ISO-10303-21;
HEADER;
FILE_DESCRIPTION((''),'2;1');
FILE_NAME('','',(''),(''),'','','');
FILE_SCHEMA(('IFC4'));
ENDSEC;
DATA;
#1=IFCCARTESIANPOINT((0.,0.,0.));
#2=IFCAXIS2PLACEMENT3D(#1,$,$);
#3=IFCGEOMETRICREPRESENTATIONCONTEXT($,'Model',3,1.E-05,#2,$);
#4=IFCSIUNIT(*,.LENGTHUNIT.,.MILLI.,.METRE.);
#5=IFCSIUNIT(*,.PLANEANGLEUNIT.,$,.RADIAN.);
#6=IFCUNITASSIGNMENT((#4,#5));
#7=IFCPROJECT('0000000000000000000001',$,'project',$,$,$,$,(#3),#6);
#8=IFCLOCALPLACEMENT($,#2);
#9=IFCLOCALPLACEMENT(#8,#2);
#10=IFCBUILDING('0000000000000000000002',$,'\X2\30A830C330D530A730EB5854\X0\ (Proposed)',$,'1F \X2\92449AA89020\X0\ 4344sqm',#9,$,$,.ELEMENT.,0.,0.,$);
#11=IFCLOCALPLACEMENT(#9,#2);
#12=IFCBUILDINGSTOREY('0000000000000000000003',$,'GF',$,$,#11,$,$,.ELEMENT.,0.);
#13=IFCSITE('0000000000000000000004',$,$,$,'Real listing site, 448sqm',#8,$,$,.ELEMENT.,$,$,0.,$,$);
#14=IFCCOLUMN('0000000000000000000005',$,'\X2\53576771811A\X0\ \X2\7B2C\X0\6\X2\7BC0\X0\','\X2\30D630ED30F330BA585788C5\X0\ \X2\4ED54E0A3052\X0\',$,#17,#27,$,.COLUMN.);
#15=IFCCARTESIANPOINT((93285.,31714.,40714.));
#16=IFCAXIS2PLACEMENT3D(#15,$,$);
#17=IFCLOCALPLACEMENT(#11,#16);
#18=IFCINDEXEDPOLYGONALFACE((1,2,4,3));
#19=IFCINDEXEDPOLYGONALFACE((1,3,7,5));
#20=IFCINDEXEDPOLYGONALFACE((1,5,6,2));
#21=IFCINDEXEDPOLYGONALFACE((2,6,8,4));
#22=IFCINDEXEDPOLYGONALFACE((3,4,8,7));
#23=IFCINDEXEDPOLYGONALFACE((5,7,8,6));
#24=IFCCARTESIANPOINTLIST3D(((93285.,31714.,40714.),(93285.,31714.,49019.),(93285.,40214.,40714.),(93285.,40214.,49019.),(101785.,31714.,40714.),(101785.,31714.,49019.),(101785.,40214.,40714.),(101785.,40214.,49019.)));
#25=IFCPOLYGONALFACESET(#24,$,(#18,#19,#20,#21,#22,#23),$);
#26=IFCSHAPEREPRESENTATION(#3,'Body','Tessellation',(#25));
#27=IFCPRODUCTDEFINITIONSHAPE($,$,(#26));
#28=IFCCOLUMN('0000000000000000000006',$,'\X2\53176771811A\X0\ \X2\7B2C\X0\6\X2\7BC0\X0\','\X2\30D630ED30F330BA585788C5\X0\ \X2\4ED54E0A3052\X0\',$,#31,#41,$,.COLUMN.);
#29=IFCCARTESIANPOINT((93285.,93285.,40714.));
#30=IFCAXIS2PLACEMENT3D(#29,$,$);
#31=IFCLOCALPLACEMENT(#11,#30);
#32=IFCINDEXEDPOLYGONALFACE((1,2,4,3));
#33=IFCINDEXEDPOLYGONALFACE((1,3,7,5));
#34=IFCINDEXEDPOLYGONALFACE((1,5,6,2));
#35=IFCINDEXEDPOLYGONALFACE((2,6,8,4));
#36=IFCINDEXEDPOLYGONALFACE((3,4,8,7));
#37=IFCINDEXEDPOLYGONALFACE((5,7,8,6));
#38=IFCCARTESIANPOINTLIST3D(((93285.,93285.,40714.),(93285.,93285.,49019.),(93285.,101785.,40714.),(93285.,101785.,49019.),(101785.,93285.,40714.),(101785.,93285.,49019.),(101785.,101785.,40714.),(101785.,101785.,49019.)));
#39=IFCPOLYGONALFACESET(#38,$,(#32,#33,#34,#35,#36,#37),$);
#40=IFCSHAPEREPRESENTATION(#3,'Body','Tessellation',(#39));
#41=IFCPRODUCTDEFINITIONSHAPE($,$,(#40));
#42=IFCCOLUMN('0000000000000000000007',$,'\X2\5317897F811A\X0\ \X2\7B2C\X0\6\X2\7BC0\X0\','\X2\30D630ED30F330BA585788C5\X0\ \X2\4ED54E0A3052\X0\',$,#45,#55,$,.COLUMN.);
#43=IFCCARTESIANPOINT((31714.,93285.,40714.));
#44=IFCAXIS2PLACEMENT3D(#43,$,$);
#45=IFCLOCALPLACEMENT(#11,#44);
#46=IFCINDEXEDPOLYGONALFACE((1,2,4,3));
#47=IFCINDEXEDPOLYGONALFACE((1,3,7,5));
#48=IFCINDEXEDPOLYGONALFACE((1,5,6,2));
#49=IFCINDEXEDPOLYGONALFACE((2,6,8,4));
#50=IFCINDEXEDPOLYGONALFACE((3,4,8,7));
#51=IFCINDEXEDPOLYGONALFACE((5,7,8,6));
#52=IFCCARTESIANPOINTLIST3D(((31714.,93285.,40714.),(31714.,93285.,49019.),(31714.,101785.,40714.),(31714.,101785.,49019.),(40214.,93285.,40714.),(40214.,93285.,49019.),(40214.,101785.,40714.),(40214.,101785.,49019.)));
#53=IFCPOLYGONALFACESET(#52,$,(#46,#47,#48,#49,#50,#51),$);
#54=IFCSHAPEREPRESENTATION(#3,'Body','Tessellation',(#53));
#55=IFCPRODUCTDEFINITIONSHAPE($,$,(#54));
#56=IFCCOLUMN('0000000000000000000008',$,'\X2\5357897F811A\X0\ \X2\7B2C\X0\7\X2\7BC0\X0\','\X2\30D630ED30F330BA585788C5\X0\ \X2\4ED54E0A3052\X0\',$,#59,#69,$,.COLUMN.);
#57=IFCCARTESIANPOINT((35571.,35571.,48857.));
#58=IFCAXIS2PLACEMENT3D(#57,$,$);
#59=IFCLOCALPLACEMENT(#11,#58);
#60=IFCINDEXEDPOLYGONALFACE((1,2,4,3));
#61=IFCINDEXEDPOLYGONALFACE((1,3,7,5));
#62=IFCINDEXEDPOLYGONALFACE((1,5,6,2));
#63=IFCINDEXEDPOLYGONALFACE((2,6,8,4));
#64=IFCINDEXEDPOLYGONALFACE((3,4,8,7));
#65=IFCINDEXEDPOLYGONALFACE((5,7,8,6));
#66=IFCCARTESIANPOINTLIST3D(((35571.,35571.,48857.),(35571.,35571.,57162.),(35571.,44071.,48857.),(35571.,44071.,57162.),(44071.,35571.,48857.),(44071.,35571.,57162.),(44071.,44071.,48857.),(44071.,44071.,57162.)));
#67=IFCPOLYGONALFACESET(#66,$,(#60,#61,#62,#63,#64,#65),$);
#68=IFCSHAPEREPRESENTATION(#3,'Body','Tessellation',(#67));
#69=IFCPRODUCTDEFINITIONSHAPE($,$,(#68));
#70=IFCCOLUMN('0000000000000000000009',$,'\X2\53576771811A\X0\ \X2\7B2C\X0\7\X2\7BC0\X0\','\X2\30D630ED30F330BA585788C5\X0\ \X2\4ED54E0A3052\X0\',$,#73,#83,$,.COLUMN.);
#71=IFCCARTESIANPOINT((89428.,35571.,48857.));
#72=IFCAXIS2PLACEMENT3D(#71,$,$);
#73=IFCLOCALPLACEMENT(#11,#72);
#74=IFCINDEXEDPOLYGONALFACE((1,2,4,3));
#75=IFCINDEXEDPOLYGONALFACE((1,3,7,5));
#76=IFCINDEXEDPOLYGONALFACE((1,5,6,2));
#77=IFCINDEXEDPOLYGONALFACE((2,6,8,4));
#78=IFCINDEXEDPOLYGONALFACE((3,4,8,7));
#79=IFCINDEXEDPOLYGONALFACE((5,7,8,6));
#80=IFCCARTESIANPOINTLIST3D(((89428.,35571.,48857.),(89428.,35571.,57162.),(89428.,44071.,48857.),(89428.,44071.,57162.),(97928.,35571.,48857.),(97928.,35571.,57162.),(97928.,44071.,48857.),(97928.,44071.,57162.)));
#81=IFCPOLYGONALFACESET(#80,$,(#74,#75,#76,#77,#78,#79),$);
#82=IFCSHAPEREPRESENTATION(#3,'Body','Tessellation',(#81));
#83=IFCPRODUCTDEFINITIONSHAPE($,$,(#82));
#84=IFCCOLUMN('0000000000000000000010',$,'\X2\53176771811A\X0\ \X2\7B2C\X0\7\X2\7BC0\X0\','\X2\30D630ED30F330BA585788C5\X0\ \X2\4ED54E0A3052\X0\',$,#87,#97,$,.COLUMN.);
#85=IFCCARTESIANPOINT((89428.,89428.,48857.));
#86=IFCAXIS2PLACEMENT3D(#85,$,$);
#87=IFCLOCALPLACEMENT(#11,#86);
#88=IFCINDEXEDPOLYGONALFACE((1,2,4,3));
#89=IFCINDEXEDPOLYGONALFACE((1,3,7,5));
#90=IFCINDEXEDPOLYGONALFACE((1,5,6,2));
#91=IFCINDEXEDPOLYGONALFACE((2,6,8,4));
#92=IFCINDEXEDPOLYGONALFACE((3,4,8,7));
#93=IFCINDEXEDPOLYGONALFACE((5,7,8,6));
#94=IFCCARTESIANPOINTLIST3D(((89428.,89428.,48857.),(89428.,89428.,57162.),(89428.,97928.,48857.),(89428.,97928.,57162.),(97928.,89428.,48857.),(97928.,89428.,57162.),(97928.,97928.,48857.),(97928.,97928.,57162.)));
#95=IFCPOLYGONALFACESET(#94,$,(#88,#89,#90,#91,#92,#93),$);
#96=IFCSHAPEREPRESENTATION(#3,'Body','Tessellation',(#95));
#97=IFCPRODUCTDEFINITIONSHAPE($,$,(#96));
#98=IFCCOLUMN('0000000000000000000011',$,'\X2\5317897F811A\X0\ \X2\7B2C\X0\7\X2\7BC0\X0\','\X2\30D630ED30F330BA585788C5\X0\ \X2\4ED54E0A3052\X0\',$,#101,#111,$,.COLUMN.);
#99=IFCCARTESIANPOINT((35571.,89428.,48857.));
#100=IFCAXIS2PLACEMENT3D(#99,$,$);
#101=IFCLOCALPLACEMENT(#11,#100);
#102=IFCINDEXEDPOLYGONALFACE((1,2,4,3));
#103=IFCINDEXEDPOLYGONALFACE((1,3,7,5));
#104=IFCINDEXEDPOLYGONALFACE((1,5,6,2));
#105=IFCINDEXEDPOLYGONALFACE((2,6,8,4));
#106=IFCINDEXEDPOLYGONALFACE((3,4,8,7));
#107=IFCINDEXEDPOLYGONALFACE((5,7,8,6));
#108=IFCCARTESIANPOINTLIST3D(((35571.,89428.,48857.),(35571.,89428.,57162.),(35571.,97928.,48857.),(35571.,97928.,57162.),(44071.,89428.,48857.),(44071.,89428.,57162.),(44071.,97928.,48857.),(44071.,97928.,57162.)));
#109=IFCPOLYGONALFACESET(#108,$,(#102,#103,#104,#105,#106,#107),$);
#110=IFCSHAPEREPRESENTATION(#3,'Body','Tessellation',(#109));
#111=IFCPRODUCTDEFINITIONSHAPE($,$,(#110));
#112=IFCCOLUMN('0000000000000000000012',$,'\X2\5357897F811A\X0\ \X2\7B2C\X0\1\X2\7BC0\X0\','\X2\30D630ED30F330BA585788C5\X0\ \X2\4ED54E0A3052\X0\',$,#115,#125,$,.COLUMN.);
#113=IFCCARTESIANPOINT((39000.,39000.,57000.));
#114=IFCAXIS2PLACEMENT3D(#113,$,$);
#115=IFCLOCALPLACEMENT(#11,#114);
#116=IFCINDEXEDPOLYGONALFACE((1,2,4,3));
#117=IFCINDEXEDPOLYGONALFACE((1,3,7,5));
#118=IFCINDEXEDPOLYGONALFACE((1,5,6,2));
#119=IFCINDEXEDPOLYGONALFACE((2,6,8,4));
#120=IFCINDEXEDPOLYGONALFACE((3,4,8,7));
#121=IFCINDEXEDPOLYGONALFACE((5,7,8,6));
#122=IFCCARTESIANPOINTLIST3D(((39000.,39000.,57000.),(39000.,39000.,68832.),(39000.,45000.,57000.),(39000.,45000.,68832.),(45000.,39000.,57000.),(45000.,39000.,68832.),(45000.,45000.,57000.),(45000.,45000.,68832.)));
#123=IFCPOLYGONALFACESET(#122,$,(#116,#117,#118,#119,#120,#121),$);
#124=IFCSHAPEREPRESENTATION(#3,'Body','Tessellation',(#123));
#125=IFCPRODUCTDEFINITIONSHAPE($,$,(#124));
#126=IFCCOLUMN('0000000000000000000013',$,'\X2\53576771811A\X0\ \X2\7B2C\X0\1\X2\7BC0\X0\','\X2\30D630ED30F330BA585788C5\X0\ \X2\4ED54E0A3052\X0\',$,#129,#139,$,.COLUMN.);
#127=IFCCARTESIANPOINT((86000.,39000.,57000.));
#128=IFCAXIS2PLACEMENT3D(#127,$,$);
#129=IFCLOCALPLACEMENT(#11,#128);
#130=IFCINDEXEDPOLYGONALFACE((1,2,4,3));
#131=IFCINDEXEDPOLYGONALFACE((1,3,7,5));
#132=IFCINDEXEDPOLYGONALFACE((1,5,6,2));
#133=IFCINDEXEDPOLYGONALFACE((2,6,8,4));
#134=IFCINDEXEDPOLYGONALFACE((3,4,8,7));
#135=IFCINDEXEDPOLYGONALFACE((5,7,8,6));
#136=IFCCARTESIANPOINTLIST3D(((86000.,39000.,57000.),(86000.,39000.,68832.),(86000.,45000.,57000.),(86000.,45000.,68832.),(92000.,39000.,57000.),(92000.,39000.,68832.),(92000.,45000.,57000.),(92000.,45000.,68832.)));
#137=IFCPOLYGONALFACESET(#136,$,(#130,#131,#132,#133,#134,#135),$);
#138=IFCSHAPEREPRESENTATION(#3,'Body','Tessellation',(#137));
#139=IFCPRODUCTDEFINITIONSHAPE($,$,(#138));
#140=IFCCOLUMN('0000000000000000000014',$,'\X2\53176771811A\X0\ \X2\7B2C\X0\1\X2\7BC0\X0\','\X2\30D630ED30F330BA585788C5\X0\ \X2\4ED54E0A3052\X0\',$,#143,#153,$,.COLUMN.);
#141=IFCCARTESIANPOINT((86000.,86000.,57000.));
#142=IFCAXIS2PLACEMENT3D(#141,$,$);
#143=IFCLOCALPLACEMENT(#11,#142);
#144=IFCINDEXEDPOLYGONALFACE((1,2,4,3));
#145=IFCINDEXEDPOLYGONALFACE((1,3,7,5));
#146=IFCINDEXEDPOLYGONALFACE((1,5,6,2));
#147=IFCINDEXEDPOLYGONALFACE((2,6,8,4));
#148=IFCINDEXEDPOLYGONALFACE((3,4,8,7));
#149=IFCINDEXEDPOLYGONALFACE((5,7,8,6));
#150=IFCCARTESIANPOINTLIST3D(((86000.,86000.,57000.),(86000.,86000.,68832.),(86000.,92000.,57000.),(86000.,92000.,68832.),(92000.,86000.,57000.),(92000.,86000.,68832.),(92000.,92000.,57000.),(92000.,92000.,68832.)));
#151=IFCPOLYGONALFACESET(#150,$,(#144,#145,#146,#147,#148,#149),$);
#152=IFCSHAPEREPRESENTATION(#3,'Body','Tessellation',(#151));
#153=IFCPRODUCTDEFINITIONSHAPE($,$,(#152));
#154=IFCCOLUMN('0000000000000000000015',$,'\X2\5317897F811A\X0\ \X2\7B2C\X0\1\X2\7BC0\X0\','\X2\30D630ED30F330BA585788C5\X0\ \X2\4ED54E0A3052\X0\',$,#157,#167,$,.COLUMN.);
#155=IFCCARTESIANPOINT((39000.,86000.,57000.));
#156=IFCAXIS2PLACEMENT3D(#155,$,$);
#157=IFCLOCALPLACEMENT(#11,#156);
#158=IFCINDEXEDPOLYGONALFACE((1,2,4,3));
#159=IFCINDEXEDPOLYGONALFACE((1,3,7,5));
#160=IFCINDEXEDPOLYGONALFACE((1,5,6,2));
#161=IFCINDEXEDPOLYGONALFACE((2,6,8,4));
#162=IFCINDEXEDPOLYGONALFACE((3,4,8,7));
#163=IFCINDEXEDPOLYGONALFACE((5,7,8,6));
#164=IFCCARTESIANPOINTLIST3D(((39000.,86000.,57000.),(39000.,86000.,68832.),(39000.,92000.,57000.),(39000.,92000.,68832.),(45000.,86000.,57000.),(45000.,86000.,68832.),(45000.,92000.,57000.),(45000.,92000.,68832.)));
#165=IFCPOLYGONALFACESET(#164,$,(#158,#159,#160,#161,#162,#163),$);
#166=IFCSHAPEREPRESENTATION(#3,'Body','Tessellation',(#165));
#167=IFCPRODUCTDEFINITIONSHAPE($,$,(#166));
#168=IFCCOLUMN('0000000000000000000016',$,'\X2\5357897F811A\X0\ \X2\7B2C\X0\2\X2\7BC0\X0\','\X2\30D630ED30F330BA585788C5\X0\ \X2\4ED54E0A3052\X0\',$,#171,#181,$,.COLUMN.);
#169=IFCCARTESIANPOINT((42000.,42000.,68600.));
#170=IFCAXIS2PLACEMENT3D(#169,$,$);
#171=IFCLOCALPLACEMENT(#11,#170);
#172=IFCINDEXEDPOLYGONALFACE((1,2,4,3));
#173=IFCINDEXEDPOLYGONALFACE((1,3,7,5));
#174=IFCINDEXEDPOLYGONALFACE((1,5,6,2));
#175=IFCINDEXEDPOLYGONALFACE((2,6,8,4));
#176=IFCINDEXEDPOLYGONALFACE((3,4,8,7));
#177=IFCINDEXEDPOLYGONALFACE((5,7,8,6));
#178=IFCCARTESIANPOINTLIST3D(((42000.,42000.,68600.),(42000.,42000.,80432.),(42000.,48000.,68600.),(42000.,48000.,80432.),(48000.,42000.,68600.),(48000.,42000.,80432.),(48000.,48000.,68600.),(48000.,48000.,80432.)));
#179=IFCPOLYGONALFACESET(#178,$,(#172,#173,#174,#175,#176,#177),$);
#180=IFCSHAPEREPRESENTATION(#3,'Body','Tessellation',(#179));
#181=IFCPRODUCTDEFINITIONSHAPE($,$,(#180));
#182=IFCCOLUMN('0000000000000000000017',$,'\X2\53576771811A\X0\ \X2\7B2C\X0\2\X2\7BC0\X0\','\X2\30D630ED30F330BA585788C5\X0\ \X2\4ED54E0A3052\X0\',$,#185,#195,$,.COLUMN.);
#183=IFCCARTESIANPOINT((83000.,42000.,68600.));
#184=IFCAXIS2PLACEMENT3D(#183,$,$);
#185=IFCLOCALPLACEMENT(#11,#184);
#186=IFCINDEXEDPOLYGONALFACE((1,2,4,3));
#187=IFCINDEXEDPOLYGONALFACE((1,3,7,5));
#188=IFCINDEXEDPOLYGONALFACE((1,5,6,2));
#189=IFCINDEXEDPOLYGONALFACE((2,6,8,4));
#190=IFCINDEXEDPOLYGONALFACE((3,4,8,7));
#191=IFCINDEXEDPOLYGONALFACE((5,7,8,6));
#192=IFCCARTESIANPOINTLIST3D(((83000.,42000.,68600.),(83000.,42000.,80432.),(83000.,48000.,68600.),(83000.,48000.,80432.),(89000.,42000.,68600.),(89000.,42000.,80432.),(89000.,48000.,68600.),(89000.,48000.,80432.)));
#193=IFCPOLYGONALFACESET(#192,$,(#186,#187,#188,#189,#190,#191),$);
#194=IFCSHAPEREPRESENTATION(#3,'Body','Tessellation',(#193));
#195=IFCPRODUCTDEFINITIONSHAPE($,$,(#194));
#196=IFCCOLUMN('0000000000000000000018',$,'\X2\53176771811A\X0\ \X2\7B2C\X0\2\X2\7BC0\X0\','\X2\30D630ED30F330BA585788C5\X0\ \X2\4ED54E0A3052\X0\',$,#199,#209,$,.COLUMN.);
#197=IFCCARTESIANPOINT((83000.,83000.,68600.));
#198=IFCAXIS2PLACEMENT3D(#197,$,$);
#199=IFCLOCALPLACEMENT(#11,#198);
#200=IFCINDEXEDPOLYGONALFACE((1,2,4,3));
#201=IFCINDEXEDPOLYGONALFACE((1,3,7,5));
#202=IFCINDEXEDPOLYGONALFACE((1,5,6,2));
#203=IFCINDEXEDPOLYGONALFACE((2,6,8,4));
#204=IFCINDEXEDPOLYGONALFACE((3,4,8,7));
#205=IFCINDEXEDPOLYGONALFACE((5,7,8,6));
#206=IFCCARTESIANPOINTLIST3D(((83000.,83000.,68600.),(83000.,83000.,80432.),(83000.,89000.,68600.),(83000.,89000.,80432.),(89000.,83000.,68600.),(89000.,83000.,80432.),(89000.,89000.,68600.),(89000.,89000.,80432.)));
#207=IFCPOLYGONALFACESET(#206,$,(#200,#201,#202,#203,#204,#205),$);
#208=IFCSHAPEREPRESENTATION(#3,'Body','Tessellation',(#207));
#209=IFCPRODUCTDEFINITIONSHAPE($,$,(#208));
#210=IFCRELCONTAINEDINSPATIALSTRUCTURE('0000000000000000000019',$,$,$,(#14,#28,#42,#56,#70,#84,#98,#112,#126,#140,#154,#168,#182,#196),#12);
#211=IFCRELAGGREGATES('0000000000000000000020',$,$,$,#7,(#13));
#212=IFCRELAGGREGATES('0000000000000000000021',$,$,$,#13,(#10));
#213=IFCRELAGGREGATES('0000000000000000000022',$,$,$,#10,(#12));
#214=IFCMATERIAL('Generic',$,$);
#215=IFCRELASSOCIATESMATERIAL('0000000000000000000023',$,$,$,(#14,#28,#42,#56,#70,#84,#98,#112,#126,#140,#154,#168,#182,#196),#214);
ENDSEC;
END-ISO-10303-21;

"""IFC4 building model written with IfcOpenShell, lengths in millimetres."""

from ifc_helpers import new_model, si_unit, frame, frame_2d, origin, place, context, project, spatial, rectangle, extrude, material, element, save


model = new_model("IFC4")

# Units and contexts
model_context = context("Model", 3, precision=1e-05, world=origin())
ifc_project = project(units=[si_unit("LENGTHUNIT", "METRE", prefix="MILLI"), si_unit("PLANEANGLEUNIT", "RADIAN")], contexts=[model_context])

# Site, building, storey
site_placement = place(None, origin())
site = spatial("IfcSite", under=ifc_project, at=site_placement, ObjectType="Real listing site, 448sqm", CompositionType="ELEMENT", RefElevation=0.0)
building_placement = place(site_placement, origin())
building = spatial("IfcBuilding", under=site, at=building_placement, Name="エッフェル塔 (Proposed)", ObjectType="1F 鉄骨造 4344sqm", CompositionType="ELEMENT", ElevationOfRefHeight=0.0, ElevationOfTerrain=0.0)
storey_placement = place(building_placement, origin())
storey = spatial("IfcBuildingStorey", under=building, at=storey_placement, Name="GF", CompositionType="ELEMENT", Elevation=0.0)

# Columns
ifc_material = material(Name="Generic")
column_1_placement = place(storey_placement, frame((93285.0, 31714.0, 40714.0)))
element("IfcColumn", 1, at=column_1_placement, inside=storey, material=ifc_material, Name="南東脚 第6節", Description="ブロンズ塗装 仕上げ", PredefinedType="COLUMN", context=model_context, shape_type="SweptSolid", body=[
    extrude(rectangle(XDim=8500.0, YDim=8500.0, at=frame_2d((4250.0, 4250.0))), frame((93285.0, 31714.0, 40714.0)), (0.0, 0.0, 1.0), 8305.0),
])
column_2_placement = place(storey_placement, frame((93285.0, 93285.0, 40714.0)))
element("IfcColumn", 2, at=column_2_placement, inside=storey, material=ifc_material, Name="北東脚 第6節", Description="ブロンズ塗装 仕上げ", PredefinedType="COLUMN", context=model_context, shape_type="SweptSolid", body=[
    extrude(rectangle(XDim=8500.0, YDim=8500.0, at=frame_2d((4250.0, 4250.0))), frame((93285.0, 93285.0, 40714.0)), (0.0, 0.0, 1.0), 8305.0),
])
column_3_placement = place(storey_placement, frame((31714.0, 93285.0, 40714.0)))
element("IfcColumn", 3, at=column_3_placement, inside=storey, material=ifc_material, Name="北西脚 第6節", Description="ブロンズ塗装 仕上げ", PredefinedType="COLUMN", context=model_context, shape_type="SweptSolid", body=[
    extrude(rectangle(XDim=8500.0, YDim=8500.0, at=frame_2d((4250.0, 4250.0))), frame((31714.0, 93285.0, 40714.0)), (0.0, 0.0, 1.0), 8305.0),
])
column_4_placement = place(storey_placement, frame((35571.0, 35571.0, 48857.0)))
element("IfcColumn", 4, at=column_4_placement, inside=storey, material=ifc_material, Name="南西脚 第7節", Description="ブロンズ塗装 仕上げ", PredefinedType="COLUMN", context=model_context, shape_type="SweptSolid", body=[
    extrude(rectangle(XDim=8500.0, YDim=8500.0, at=frame_2d((4250.0, 4250.0))), frame((35571.0, 35571.0, 48857.0)), (0.0, 0.0, 1.0), 8305.0),
])
column_5_placement = place(storey_placement, frame((89428.0, 35571.0, 48857.0)))
element("IfcColumn", 5, at=column_5_placement, inside=storey, material=ifc_material, Name="南東脚 第7節", Description="ブロンズ塗装 仕上げ", PredefinedType="COLUMN", context=model_context, shape_type="SweptSolid", body=[
    extrude(rectangle(XDim=8500.0, YDim=8500.0, at=frame_2d((4250.0, 4250.0))), frame((89428.0, 35571.0, 48857.0)), (0.0, 0.0, 1.0), 8305.0),
])
column_6_placement = place(storey_placement, frame((89428.0, 89428.0, 48857.0)))
element("IfcColumn", 6, at=column_6_placement, inside=storey, material=ifc_material, Name="北東脚 第7節", Description="ブロンズ塗装 仕上げ", PredefinedType="COLUMN", context=model_context, shape_type="SweptSolid", body=[
    extrude(rectangle(XDim=8500.0, YDim=8500.0, at=frame_2d((4250.0, 4250.0))), frame((89428.0, 89428.0, 48857.0)), (0.0, 0.0, 1.0), 8305.0),
])
column_7_placement = place(storey_placement, frame((35571.0, 89428.0, 48857.0)))
element("IfcColumn", 7, at=column_7_placement, inside=storey, material=ifc_material, Name="北西脚 第7節", Description="ブロンズ塗装 仕上げ", PredefinedType="COLUMN", context=model_context, shape_type="SweptSolid", body=[
    extrude(rectangle(XDim=8500.0, YDim=8500.0, at=frame_2d((4250.0, 4250.0))), frame((35571.0, 89428.0, 48857.0)), (0.0, 0.0, 1.0), 8305.0),
])
column_8_placement = place(storey_placement, frame((39000.0, 39000.0, 57000.0)))
element("IfcColumn", 8, at=column_8_placement, inside=storey, material=ifc_material, Name="南西脚 第1節", Description="ブロンズ塗装 仕上げ", PredefinedType="COLUMN", context=model_context, shape_type="SweptSolid", body=[
    extrude(rectangle(XDim=6000.0, YDim=6000.0, at=frame_2d((3000.0, 3000.0))), frame((39000.0, 39000.0, 57000.0)), (0.0, 0.0, 1.0), 11832.0),
])
column_9_placement = place(storey_placement, frame((86000.0, 39000.0, 57000.0)))
element("IfcColumn", 9, at=column_9_placement, inside=storey, material=ifc_material, Name="南東脚 第1節", Description="ブロンズ塗装 仕上げ", PredefinedType="COLUMN", context=model_context, shape_type="SweptSolid", body=[
    extrude(rectangle(XDim=6000.0, YDim=6000.0, at=frame_2d((3000.0, 3000.0))), frame((86000.0, 39000.0, 57000.0)), (0.0, 0.0, 1.0), 11832.0),
])
column_10_placement = place(storey_placement, frame((86000.0, 86000.0, 57000.0)))
element("IfcColumn", 10, at=column_10_placement, inside=storey, material=ifc_material, Name="北東脚 第1節", Description="ブロンズ塗装 仕上げ", PredefinedType="COLUMN", context=model_context, shape_type="SweptSolid", body=[
    extrude(rectangle(XDim=6000.0, YDim=6000.0, at=frame_2d((3000.0, 3000.0))), frame((86000.0, 86000.0, 57000.0)), (0.0, 0.0, 1.0), 11832.0),
])
column_11_placement = place(storey_placement, frame((39000.0, 86000.0, 57000.0)))
element("IfcColumn", 11, at=column_11_placement, inside=storey, material=ifc_material, Name="北西脚 第1節", Description="ブロンズ塗装 仕上げ", PredefinedType="COLUMN", context=model_context, shape_type="SweptSolid", body=[
    extrude(rectangle(XDim=6000.0, YDim=6000.0, at=frame_2d((3000.0, 3000.0))), frame((39000.0, 86000.0, 57000.0)), (0.0, 0.0, 1.0), 11832.0),
])
column_12_placement = place(storey_placement, frame((42000.0, 42000.0, 68600.0)))
element("IfcColumn", 12, at=column_12_placement, inside=storey, material=ifc_material, Name="南西脚 第2節", Description="ブロンズ塗装 仕上げ", PredefinedType="COLUMN", context=model_context, shape_type="SweptSolid", body=[
    extrude(rectangle(XDim=6000.0, YDim=6000.0, at=frame_2d((3000.0, 3000.0))), frame((42000.0, 42000.0, 68600.0)), (0.0, 0.0, 1.0), 11832.0),
])
column_13_placement = place(storey_placement, frame((83000.0, 42000.0, 68600.0)))
element("IfcColumn", 13, at=column_13_placement, inside=storey, material=ifc_material, Name="南東脚 第2節", Description="ブロンズ塗装 仕上げ", PredefinedType="COLUMN", context=model_context, shape_type="SweptSolid", body=[
    extrude(rectangle(XDim=6000.0, YDim=6000.0, at=frame_2d((3000.0, 3000.0))), frame((83000.0, 42000.0, 68600.0)), (0.0, 0.0, 1.0), 11832.0),
])
column_14_placement = place(storey_placement, frame((83000.0, 83000.0, 68600.0)))
element("IfcColumn", 14, at=column_14_placement, inside=storey, material=ifc_material, Name="北東脚 第2節", Description="ブロンズ塗装 仕上げ", PredefinedType="COLUMN", context=model_context, shape_type="SweptSolid", body=[
    extrude(rectangle(XDim=6000.0, YDim=6000.0, at=frame_2d((3000.0, 3000.0))), frame((83000.0, 83000.0, 68600.0)), (0.0, 0.0, 1.0), 11832.0),
])

save(model, "model.ifc")
